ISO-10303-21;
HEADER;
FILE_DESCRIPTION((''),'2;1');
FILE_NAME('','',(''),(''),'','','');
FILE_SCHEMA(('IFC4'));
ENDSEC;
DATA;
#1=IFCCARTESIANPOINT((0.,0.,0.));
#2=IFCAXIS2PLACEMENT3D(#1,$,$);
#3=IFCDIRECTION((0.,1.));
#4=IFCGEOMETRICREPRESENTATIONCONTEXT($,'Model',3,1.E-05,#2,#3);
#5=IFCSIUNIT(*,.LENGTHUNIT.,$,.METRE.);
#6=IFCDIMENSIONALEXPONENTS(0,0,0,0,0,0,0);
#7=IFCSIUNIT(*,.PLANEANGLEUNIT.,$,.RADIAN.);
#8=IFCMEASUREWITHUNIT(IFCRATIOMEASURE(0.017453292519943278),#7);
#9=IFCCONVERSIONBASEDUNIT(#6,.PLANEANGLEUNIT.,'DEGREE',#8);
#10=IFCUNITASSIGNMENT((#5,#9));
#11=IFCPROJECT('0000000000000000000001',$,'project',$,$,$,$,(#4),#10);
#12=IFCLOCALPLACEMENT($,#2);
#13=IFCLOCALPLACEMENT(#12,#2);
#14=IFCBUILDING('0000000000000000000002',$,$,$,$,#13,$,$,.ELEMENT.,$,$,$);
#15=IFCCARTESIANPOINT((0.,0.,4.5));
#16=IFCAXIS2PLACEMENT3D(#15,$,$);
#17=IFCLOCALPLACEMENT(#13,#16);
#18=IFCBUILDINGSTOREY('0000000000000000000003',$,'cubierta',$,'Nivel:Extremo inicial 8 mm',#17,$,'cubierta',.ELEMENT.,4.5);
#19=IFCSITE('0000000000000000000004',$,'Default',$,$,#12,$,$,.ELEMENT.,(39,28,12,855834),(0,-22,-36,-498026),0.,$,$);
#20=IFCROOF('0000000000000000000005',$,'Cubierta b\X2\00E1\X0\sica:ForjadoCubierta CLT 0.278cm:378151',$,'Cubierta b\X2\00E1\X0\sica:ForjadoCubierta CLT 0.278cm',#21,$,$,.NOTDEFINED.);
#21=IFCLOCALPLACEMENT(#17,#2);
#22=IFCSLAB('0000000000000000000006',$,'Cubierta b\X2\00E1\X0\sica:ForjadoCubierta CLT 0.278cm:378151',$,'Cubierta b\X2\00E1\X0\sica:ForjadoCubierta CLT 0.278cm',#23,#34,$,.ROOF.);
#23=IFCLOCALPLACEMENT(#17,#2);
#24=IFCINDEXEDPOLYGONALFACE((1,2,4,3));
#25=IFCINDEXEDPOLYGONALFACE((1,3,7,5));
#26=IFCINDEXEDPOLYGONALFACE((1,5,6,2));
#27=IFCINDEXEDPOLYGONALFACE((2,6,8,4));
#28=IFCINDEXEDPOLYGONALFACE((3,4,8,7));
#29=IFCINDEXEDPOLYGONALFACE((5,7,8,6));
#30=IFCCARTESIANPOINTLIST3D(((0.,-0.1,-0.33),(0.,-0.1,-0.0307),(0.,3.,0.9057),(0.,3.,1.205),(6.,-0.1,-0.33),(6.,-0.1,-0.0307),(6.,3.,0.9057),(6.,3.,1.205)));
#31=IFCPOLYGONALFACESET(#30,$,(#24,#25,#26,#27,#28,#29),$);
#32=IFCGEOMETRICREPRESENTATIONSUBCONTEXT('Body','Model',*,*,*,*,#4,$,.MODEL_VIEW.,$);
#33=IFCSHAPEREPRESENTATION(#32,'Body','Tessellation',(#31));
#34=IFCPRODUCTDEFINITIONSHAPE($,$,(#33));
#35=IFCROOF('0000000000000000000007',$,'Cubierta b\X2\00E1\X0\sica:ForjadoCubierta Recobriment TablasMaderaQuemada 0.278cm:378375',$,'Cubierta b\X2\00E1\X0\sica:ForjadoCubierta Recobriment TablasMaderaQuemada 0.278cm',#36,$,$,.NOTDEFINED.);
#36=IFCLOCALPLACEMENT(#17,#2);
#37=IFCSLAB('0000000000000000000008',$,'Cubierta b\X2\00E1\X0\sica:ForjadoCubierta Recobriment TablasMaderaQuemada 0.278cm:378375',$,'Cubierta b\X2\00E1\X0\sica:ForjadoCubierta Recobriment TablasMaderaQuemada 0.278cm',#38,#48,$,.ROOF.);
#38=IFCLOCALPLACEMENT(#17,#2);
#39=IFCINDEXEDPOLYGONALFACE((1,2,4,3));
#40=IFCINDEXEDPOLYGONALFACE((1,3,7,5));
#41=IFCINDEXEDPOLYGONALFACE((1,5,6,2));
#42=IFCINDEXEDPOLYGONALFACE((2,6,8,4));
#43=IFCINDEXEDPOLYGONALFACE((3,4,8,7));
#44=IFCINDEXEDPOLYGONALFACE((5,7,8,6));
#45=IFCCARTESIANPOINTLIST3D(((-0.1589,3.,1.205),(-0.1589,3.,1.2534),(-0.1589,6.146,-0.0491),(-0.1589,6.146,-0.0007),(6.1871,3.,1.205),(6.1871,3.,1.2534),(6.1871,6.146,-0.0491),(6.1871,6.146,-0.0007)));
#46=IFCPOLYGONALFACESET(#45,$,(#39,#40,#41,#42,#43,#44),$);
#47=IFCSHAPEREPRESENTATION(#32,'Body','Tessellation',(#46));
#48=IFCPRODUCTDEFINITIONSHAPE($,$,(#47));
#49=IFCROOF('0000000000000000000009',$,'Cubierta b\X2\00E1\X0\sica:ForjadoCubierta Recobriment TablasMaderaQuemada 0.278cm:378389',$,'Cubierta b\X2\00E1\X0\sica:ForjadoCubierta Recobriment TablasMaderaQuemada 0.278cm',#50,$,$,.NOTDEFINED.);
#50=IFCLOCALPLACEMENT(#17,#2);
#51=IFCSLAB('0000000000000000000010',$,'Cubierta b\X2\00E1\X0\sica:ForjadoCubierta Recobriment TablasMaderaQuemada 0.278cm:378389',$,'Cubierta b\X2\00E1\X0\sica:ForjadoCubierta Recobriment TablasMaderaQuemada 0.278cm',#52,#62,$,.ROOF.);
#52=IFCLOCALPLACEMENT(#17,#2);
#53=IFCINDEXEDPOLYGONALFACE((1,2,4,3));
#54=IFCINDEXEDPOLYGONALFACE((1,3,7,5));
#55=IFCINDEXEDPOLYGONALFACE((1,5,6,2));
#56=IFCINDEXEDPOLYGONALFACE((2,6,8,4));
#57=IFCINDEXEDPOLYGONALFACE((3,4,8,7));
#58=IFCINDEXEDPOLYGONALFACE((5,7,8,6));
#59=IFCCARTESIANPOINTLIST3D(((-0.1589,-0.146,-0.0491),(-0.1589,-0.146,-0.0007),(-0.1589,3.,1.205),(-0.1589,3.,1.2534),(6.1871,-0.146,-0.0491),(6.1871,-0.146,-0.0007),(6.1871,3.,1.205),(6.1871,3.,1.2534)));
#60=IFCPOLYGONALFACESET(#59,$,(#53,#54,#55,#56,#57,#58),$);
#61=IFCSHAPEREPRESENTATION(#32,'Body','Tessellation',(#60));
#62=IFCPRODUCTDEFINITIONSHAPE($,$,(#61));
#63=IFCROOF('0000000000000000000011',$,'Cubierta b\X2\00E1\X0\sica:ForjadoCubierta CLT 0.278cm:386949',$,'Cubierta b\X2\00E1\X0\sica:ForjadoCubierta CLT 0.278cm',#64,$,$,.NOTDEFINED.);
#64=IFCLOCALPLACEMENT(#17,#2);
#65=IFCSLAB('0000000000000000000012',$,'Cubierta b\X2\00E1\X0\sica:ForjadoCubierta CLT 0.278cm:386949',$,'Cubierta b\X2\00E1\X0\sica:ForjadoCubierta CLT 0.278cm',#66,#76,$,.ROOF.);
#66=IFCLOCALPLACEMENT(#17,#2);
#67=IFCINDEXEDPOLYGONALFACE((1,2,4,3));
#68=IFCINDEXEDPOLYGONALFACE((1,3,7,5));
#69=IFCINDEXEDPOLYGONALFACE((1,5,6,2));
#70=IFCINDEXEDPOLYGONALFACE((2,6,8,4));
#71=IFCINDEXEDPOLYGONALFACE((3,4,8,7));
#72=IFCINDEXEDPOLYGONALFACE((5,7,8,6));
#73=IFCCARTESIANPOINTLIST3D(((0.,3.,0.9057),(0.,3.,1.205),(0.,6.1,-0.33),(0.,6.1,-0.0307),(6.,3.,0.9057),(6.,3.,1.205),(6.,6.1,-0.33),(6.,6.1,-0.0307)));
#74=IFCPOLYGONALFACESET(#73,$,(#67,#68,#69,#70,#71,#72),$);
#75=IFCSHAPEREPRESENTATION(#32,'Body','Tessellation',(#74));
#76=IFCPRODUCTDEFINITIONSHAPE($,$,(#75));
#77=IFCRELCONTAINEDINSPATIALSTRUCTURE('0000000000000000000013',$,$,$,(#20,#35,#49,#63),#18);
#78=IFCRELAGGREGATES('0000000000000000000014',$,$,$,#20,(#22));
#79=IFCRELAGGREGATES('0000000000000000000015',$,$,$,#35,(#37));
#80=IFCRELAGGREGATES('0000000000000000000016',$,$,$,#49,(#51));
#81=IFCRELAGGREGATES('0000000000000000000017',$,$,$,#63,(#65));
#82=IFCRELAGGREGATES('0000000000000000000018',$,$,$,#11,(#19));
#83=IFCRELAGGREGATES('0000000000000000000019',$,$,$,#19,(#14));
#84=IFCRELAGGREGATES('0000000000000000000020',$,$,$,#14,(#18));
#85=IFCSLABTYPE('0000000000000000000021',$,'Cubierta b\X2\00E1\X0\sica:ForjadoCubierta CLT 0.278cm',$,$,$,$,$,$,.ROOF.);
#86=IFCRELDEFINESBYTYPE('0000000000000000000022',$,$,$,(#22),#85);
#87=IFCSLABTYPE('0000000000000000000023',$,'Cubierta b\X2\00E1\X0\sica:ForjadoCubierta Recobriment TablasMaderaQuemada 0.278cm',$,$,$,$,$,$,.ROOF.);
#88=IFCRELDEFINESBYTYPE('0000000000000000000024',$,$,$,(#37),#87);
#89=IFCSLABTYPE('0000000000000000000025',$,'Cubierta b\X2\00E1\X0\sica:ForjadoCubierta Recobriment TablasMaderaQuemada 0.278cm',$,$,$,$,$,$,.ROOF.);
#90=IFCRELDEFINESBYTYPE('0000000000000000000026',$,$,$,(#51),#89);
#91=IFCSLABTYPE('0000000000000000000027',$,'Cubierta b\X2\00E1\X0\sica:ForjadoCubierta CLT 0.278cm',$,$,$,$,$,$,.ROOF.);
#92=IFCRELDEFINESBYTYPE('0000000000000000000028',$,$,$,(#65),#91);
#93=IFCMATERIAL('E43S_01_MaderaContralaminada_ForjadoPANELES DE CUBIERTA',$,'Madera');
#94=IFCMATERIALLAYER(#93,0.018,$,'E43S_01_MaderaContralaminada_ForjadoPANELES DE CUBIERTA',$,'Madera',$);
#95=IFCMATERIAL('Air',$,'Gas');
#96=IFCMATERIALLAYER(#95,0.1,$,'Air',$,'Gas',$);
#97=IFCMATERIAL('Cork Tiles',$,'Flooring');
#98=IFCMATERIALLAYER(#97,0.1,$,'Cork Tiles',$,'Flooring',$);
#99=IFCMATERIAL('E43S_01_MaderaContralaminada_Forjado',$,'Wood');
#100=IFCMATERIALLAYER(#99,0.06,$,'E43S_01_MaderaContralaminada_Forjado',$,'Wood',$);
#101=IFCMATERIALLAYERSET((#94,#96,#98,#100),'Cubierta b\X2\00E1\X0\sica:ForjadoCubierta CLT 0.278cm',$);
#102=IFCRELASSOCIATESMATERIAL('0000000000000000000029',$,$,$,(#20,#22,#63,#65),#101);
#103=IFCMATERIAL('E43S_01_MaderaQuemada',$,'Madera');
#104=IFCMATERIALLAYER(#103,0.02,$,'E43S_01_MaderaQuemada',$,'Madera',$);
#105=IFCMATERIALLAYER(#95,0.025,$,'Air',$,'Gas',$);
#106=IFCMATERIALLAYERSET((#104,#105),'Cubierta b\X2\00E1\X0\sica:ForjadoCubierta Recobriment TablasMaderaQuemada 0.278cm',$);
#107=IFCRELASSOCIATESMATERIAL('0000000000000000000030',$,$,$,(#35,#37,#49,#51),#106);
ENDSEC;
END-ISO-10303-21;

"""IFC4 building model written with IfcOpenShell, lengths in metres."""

from ifc_helpers import new_model, entity, si_unit, converted_unit, direction, frame, frame_2d, origin, place, context, subcontext, project, spatial, rectangle, extrude, material, layer, layer_set, type_object, element, aggregate, save


model = new_model("IFC4")

# Units and contexts
model_context = context("Model", 3, precision=1e-05, world=origin(), true_north=direction((0.0, 1.0)))
body_context = subcontext(model_context, "Body", "Model", "MODEL_VIEW")
ifc_project = project(units=[si_unit("LENGTHUNIT", "METRE"), converted_unit("PLANEANGLEUNIT", "DEGREE", entity("IfcRatioMeasure", 0.017453292519943278), si_unit("PLANEANGLEUNIT", "RADIAN"), dimensions=[0, 0, 0, 0, 0, 0, 0])], contexts=[model_context])

# Site, building, storey
site_placement = place(None, origin())
site = spatial("IfcSite", under=ifc_project, at=site_placement, Name="Default", CompositionType="ELEMENT", RefLatitude=(39, 28, 12, 855834), RefLongitude=(0, -22, -36, -498026), RefElevation=0.0)
building_placement = place(site_placement, origin())
building = spatial("IfcBuilding", under=site, at=building_placement, CompositionType="ELEMENT")
storey_placement = place(building_placement, frame((0.0, 0.0, 4.5)))
storey = spatial("IfcBuildingStorey", under=building, at=storey_placement, Name="cubierta", ObjectType="Nivel:Extremo inicial 8 mm", LongName="cubierta", CompositionType="ELEMENT", Elevation=4.5)

# Roofs, slabs
ifc_material_1 = material(Name="E43S_01_MaderaContralaminada_ForjadoPANELES DE CUBIERTA", Category="Madera")
ifc_layer_1 = layer(ifc_material_1, 0.018, Name="E43S_01_MaderaContralaminada_ForjadoPANELES DE CUBIERTA", Category="Madera")
ifc_material_2 = material(Name="Air", Category="Gas")
ifc_layer_2 = layer(ifc_material_2, 0.1, Name="Air", Category="Gas")
ifc_material_3 = material(Name="Cork Tiles", Category="Flooring")
ifc_layer_3 = layer(ifc_material_3, 0.1, Name="Cork Tiles", Category="Flooring")
ifc_material_4 = material(Name="E43S_01_MaderaContralaminada_Forjado", Category="Wood")
ifc_layer_4 = layer(ifc_material_4, 0.06, Name="E43S_01_MaderaContralaminada_Forjado", Category="Wood")
ifc_layer_set_1 = layer_set([ifc_layer_1, ifc_layer_2, ifc_layer_3, ifc_layer_4], Name="Cubierta básica:ForjadoCubierta CLT 0.278cm")
roof_1_placement = place(storey_placement, frame((0.0, -0.1, -0.33)))
roof_1 = element("IfcRoof", 1, at=roof_1_placement, inside=storey, material=ifc_layer_set_1, Name="Cubierta básica:ForjadoCubierta CLT 0.278cm:378151", ObjectType="Cubierta básica:ForjadoCubierta CLT 0.278cm", PredefinedType="NOTDEFINED")
slab_type_1 = type_object("IfcSlabType", Name="Cubierta básica:ForjadoCubierta CLT 0.278cm", PredefinedType="ROOF")
slab_1_placement = place(roof_1_placement, origin())
slab_1 = element("IfcSlab", 2, at=slab_1_placement, type_object=slab_type_1, material=ifc_layer_set_1, Name="Cubierta básica:ForjadoCubierta CLT 0.278cm:378151", ObjectType="Cubierta básica:ForjadoCubierta CLT 0.278cm", PredefinedType="ROOF", context=body_context, shape_type="SweptSolid", body=[
    extrude(rectangle(XDim=3.3372, YDim=6.0, at=frame_2d((0.0, 0.0), x_axis=(0.0, -1.0))), frame((3.0, 1.55, 0.6179), z_axis=(0.0, -0.370288, 0.928917), x_axis=(1.0, 0.0, 0.0)), (0.0, 0.370288, 0.928917), 0.2993),
])
aggregate(roof_1, [slab_1])
ifc_material_5 = material(Name="E43S_01_MaderaQuemada", Category="Madera")
ifc_layer_5 = layer(ifc_material_5, 0.02, Name="E43S_01_MaderaQuemada", Category="Madera")
ifc_layer_6 = layer(ifc_material_2, 0.025, Name="Air", Category="Gas")
ifc_layer_set_2 = layer_set([ifc_layer_5, ifc_layer_6], Name="Cubierta básica:ForjadoCubierta Recobriment TablasMaderaQuemada 0.278cm")
roof_2_placement = place(storey_placement, frame((-0.1589, 3.0, -0.0491)))
roof_2 = element("IfcRoof", 3, at=roof_2_placement, inside=storey, material=ifc_layer_set_2, Name="Cubierta básica:ForjadoCubierta Recobriment TablasMaderaQuemada 0.278cm:378375", ObjectType="Cubierta básica:ForjadoCubierta Recobriment TablasMaderaQuemada 0.278cm", PredefinedType="NOTDEFINED")
slab_type_2 = type_object("IfcSlabType", Name="Cubierta básica:ForjadoCubierta Recobriment TablasMaderaQuemada 0.278cm", PredefinedType="ROOF")
slab_2_placement = place(roof_2_placement, origin())
slab_2 = element("IfcSlab", 4, at=slab_2_placement, type_object=slab_type_2, material=ifc_layer_set_2, Name="Cubierta básica:ForjadoCubierta Recobriment TablasMaderaQuemada 0.278cm:378375", ObjectType="Cubierta básica:ForjadoCubierta Recobriment TablasMaderaQuemada 0.278cm", PredefinedType="ROOF", context=body_context, shape_type="SweptSolid", body=[
    extrude(rectangle(XDim=3.3867, YDim=6.346, at=frame_2d((0.0, 0.0), x_axis=(0.0, 1.0))), frame((3.173, 1.573, 0.627), z_axis=(0.0, 0.370288, 0.928917), x_axis=(1.0, 0.0, 0.0)), (0.0, -0.370288, 0.928917), 0.0484),
])
aggregate(roof_2, [slab_2])
roof_3_placement = place(storey_placement, frame((-0.1589, -0.146, -0.0491)))
roof_3 = element("IfcRoof", 5, at=roof_3_placement, inside=storey, material=ifc_layer_set_2, Name="Cubierta básica:ForjadoCubierta Recobriment TablasMaderaQuemada 0.278cm:378389", ObjectType="Cubierta básica:ForjadoCubierta Recobriment TablasMaderaQuemada 0.278cm", PredefinedType="NOTDEFINED")
slab_type_3 = type_object("IfcSlabType", Name="Cubierta básica:ForjadoCubierta Recobriment TablasMaderaQuemada 0.278cm", PredefinedType="ROOF")
slab_3_placement = place(roof_3_placement, origin())
slab_3 = element("IfcSlab", 6, at=slab_3_placement, type_object=slab_type_3, material=ifc_layer_set_2, Name="Cubierta básica:ForjadoCubierta Recobriment TablasMaderaQuemada 0.278cm:378389", ObjectType="Cubierta básica:ForjadoCubierta Recobriment TablasMaderaQuemada 0.278cm", PredefinedType="ROOF", context=body_context, shape_type="SweptSolid", body=[
    extrude(rectangle(XDim=3.3867, YDim=6.346, at=frame_2d((0.0, 0.0), x_axis=(0.0, -1.0))), frame((3.173, 1.573, 0.627), z_axis=(0.0, -0.370288, 0.928917), x_axis=(1.0, 0.0, 0.0)), (0.0, 0.370288, 0.928917), 0.0484),
])
aggregate(roof_3, [slab_3])
roof_4_placement = place(storey_placement, frame((0.0, 3.0, -0.33)))
roof_4 = element("IfcRoof", 7, at=roof_4_placement, inside=storey, material=ifc_layer_set_1, Name="Cubierta básica:ForjadoCubierta CLT 0.278cm:386949", ObjectType="Cubierta básica:ForjadoCubierta CLT 0.278cm", PredefinedType="NOTDEFINED")
slab_type_4 = type_object("IfcSlabType", Name="Cubierta básica:ForjadoCubierta CLT 0.278cm", PredefinedType="ROOF")
slab_4_placement = place(roof_4_placement, origin())
slab_4 = element("IfcSlab", 8, at=slab_4_placement, type_object=slab_type_4, material=ifc_layer_set_1, Name="Cubierta básica:ForjadoCubierta CLT 0.278cm:386949", ObjectType="Cubierta básica:ForjadoCubierta CLT 0.278cm", PredefinedType="ROOF", context=body_context, shape_type="SweptSolid", body=[
    extrude(rectangle(XDim=3.3372, YDim=6.0, at=frame_2d((0.0, 0.0), x_axis=(0.0, 1.0))), frame((3.0, 1.55, 0.6179), z_axis=(0.0, 0.370288, 0.928917), x_axis=(1.0, 0.0, 0.0)), (0.0, -0.370288, 0.928917), 0.2993),
])
aggregate(roof_4, [slab_4])

save(model, "model.ifc")
